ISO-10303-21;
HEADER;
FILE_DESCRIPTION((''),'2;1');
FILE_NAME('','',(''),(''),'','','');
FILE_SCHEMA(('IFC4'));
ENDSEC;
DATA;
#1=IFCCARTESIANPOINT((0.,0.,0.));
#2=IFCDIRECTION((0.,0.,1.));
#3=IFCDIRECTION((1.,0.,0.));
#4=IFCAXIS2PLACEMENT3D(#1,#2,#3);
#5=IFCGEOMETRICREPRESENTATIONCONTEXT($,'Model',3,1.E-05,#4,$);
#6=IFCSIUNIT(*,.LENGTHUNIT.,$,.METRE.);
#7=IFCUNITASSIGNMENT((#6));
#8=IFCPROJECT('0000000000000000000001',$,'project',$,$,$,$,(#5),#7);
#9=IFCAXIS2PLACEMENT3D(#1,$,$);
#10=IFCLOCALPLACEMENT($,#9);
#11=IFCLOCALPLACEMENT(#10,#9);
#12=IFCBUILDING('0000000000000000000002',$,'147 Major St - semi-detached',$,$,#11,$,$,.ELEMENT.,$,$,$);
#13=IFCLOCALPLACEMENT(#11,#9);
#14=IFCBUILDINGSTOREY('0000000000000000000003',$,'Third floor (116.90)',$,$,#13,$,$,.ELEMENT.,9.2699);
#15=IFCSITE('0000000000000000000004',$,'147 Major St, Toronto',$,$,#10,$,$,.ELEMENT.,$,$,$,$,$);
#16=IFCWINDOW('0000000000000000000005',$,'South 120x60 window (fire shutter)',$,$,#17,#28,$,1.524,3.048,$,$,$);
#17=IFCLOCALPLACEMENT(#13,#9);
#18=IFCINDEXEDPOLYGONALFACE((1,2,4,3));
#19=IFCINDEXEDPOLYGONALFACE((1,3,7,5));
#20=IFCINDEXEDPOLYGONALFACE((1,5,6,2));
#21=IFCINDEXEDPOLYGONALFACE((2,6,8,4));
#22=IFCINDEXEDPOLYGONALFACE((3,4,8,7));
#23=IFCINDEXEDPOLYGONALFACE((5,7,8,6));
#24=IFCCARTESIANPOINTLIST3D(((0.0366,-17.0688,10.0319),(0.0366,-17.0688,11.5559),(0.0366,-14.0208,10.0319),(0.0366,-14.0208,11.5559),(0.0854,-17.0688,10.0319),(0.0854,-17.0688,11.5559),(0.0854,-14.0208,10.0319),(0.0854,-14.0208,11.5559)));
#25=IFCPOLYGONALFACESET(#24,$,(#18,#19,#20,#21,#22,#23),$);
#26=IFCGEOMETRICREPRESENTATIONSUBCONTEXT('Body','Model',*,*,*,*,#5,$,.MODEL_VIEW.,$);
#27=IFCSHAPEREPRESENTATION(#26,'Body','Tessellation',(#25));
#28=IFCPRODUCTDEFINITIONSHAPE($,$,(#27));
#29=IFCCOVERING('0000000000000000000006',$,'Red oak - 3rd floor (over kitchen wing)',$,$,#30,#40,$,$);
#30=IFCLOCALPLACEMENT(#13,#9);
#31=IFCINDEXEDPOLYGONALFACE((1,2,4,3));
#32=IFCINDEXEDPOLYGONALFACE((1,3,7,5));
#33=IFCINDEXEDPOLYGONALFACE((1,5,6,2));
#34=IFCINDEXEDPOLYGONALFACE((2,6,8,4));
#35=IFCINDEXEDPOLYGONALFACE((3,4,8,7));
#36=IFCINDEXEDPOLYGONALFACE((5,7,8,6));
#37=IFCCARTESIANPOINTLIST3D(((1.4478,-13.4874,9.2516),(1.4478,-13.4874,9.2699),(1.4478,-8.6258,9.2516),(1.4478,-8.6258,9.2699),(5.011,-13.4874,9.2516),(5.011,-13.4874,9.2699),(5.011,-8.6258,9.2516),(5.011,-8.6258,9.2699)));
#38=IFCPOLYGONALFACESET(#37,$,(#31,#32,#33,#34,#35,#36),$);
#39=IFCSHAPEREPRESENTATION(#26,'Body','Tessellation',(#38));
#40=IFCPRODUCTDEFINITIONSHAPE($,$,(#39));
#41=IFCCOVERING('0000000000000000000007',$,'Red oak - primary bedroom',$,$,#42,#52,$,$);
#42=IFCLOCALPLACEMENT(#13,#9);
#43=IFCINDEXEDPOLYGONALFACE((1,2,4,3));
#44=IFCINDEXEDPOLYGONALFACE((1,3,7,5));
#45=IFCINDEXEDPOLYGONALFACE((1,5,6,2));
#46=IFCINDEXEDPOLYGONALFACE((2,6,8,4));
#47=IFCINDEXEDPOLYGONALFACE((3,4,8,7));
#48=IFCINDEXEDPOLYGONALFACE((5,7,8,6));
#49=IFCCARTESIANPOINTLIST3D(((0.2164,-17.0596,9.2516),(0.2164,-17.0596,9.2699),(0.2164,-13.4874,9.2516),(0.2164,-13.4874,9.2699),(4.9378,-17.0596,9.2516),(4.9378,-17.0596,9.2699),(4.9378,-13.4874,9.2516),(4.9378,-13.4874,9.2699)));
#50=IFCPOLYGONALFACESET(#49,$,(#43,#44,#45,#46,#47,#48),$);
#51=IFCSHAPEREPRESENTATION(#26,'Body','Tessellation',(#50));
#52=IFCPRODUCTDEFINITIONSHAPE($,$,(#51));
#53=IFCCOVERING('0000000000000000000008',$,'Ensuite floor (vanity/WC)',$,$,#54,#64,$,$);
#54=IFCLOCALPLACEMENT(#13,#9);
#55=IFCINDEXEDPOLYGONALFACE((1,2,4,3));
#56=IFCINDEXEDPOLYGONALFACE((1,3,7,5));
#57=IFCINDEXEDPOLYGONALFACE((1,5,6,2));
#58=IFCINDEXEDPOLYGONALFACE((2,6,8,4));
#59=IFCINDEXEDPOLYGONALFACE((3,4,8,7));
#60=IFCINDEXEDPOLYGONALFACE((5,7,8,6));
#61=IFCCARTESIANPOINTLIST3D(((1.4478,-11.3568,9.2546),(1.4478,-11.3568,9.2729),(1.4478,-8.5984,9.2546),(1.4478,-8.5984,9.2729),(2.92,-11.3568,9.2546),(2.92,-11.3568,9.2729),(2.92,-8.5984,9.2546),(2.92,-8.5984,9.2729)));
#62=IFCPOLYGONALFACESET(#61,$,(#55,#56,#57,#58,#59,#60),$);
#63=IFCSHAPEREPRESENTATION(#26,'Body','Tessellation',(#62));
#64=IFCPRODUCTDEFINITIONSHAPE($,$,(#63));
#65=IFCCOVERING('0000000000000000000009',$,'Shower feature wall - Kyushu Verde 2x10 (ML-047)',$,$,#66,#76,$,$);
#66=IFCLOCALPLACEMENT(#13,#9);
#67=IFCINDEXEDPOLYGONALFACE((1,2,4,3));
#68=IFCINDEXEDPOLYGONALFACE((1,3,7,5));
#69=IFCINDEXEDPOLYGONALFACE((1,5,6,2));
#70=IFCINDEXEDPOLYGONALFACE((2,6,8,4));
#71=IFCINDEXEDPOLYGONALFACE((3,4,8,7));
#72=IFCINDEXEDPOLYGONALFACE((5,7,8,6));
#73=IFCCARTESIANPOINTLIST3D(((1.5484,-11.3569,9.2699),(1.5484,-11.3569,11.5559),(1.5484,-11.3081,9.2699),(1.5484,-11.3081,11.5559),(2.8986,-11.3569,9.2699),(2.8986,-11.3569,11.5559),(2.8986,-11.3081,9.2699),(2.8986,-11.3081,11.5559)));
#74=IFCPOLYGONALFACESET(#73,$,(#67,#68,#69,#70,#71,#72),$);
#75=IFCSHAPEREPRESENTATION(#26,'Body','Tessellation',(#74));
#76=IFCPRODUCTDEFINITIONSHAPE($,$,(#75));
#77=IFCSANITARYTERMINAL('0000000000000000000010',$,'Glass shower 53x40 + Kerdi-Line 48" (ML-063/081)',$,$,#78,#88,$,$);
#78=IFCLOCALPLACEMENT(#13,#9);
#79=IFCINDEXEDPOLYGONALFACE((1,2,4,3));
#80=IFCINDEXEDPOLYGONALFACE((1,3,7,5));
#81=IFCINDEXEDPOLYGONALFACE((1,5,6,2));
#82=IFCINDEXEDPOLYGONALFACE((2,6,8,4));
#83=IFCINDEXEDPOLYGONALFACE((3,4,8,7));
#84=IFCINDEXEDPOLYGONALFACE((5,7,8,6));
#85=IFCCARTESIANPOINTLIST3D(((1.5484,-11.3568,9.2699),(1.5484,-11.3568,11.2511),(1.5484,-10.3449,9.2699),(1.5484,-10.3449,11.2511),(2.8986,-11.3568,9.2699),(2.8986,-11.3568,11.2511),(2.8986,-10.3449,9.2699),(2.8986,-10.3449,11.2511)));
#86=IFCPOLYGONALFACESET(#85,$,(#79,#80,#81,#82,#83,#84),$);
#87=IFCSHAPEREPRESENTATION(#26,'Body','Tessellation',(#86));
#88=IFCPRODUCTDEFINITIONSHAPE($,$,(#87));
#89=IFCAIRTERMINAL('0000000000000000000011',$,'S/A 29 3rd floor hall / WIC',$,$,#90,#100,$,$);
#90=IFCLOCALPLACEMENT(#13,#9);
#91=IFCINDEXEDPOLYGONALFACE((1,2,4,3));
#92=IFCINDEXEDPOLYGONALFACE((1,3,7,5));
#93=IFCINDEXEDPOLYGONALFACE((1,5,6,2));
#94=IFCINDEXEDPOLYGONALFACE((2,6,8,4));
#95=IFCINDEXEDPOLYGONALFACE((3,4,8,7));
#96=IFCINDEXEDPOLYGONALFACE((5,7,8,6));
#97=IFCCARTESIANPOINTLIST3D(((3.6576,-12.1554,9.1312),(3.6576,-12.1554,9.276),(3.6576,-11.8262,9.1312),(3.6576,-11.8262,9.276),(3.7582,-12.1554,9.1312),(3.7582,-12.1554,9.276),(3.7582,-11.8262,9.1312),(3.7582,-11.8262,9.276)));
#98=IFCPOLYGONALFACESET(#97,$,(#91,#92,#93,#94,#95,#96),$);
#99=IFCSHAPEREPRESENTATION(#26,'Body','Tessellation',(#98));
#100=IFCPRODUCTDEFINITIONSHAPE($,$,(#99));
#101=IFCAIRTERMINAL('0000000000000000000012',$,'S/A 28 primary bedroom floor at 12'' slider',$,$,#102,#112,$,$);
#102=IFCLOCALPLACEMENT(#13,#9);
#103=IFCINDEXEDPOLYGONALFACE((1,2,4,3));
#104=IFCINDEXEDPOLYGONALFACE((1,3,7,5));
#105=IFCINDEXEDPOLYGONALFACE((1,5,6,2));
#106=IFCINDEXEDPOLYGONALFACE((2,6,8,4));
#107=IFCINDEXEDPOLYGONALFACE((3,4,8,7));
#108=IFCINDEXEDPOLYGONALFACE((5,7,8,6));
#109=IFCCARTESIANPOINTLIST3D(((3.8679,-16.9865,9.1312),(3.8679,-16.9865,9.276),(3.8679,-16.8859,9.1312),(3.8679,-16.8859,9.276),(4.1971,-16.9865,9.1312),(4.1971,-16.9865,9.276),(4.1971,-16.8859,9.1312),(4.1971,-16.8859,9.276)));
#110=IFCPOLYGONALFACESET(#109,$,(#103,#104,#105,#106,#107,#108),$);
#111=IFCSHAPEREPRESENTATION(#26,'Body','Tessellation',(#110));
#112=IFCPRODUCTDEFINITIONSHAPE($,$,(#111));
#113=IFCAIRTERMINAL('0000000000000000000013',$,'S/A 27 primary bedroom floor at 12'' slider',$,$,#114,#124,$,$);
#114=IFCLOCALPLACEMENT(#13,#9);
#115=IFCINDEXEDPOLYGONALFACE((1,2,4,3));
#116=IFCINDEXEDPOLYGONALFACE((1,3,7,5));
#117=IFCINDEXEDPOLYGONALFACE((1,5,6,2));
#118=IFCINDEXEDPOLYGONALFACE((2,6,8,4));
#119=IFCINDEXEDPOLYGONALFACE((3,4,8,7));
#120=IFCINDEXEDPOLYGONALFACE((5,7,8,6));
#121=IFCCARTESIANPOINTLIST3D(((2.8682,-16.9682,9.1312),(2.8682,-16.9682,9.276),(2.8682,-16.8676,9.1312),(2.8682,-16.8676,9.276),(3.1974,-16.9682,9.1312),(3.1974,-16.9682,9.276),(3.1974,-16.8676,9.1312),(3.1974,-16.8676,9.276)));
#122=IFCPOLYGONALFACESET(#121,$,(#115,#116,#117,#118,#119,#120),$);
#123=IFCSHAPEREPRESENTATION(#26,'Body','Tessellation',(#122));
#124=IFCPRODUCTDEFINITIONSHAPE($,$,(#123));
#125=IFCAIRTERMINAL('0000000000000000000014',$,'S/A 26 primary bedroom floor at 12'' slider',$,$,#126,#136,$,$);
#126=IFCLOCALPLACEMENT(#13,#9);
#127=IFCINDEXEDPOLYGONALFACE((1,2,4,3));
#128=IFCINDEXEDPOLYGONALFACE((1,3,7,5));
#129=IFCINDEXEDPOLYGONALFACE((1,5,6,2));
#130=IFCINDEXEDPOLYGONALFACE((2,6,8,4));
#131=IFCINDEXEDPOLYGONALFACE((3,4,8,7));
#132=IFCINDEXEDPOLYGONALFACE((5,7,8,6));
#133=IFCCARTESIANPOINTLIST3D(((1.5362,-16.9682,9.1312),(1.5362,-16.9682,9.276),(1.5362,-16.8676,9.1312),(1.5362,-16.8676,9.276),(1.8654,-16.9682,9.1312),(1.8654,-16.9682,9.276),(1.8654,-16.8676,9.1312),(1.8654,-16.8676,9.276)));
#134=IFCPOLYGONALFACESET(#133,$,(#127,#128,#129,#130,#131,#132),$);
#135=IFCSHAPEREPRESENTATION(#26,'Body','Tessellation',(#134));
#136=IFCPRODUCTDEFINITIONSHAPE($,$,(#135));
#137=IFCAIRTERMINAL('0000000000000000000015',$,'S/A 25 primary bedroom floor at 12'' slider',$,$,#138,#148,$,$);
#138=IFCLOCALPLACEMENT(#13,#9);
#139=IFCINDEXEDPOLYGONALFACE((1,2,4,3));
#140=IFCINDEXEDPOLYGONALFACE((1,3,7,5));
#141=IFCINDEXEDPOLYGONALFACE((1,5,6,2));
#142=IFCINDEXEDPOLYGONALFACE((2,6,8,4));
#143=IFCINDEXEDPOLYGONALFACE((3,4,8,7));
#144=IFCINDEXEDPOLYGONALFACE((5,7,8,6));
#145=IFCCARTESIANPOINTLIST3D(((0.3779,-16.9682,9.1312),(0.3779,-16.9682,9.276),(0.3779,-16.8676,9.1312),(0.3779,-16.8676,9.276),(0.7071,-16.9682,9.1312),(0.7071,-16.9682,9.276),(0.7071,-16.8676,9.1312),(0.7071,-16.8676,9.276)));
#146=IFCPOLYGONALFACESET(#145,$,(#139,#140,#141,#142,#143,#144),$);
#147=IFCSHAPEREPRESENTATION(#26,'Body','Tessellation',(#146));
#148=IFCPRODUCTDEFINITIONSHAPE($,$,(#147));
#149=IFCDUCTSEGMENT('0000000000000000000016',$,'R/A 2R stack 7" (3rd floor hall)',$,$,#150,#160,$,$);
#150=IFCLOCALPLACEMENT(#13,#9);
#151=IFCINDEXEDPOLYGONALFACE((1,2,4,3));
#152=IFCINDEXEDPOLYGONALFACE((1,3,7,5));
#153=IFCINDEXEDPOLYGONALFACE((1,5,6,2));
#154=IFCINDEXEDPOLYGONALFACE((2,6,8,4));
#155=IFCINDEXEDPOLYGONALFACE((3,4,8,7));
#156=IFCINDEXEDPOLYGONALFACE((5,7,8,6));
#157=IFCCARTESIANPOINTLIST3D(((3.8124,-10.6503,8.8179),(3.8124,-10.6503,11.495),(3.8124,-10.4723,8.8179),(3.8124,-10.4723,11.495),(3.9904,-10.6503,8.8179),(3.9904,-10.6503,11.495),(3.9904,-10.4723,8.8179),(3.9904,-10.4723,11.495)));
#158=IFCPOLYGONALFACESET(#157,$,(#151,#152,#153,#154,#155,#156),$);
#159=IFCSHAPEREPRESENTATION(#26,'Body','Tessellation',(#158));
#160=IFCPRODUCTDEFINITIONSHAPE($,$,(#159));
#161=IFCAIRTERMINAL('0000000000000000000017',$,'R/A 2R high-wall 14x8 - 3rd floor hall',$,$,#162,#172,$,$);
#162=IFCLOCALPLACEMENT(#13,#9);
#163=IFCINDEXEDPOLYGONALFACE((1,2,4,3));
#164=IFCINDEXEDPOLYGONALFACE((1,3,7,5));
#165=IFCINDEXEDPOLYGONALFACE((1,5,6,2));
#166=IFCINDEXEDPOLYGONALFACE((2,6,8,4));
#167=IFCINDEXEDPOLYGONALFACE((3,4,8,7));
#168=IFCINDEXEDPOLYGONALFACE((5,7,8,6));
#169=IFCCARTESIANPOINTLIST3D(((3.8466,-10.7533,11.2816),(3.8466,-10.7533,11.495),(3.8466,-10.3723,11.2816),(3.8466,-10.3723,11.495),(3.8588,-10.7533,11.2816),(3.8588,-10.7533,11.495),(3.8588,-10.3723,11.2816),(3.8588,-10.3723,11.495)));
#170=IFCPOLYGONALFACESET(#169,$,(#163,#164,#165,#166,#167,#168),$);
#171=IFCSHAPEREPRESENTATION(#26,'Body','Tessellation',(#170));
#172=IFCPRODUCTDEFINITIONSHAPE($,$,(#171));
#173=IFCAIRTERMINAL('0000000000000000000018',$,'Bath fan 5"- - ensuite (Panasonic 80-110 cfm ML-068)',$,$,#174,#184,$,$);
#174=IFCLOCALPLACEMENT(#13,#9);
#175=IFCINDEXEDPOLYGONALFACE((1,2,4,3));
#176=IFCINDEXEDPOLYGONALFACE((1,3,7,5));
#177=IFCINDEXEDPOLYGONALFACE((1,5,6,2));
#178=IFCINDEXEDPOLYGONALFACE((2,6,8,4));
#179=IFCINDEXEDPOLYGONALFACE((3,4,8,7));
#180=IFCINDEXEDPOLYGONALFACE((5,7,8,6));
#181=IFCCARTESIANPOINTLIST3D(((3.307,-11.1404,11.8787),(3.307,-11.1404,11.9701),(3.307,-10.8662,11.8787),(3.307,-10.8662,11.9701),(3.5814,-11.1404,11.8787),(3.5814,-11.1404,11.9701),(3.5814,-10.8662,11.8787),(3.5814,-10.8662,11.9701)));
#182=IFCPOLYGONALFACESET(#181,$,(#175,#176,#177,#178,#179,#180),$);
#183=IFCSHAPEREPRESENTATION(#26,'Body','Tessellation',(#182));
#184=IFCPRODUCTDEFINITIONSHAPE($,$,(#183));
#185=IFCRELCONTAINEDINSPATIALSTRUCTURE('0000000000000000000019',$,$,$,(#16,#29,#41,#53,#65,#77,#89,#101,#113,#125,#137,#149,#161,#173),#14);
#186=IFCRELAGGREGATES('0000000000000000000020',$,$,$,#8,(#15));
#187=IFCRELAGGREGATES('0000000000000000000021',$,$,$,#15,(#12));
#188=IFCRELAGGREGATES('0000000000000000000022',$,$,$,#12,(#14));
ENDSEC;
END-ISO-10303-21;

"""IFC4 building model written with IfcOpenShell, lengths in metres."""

from ifc_helpers import new_model, si_unit, frame, origin, origin_with_axes, place, context, subcontext, project, spatial, rectangle, extrude, element, save


model = new_model("IFC4")

# Units and contexts
model_context = context("Model", 3, precision=1e-05, world=origin_with_axes())
body_context = subcontext(model_context, "Body", "Model", "MODEL_VIEW")
ifc_project = project(units=[si_unit("LENGTHUNIT", "METRE")], contexts=[model_context])

# Site, building, storey
site_placement = place(None, origin())
site = spatial("IfcSite", under=ifc_project, at=site_placement, Name="147 Major St, Toronto", CompositionType="ELEMENT")
building_placement = place(site_placement, origin())
building = spatial("IfcBuilding", under=site, at=building_placement, Name="147 Major St - semi-detached", CompositionType="ELEMENT")
storey_placement = place(building_placement, origin())
storey = spatial("IfcBuildingStorey", under=building, at=storey_placement, Name="Third floor (116.90)", CompositionType="ELEMENT", Elevation=9.2699)

# Window
window_placement = place(storey_placement, frame((0.061, -15.5448, 10.0319)))
element("IfcWindow", 1, at=window_placement, inside=storey, Name="South 120x60 window (fire shutter)", OverallHeight=1.524, OverallWidth=3.048, context=body_context, shape_type="SweptSolid", body=[
    extrude(rectangle(XDim=0.0488, YDim=3.048), origin_with_axes(), (0.0, 0.0, 1.0), 1.524),
])

# Coverings
covering_1_placement = place(storey_placement, frame((3.2294, -11.0566, 9.2516)))
element("IfcCovering", 2, at=covering_1_placement, inside=storey, Name="Red oak - 3rd floor (over kitchen wing)", context=body_context, shape_type="SweptSolid", body=[
    extrude(rectangle(XDim=3.5631, YDim=4.8616), origin_with_axes(), (0.0, 0.0, 1.0), 0.0183),
])
covering_2_placement = place(storey_placement, frame((2.5771, -15.2735, 9.2516)))
element("IfcCovering", 3, at=covering_2_placement, inside=storey, Name="Red oak - primary bedroom", context=body_context, shape_type="SweptSolid", body=[
    extrude(rectangle(XDim=4.7214, YDim=3.5723), origin_with_axes(), (0.0, 0.0, 1.0), 0.0183),
])
covering_3_placement = place(storey_placement, frame((2.1839, -9.9776, 9.2546)))
element("IfcCovering", 4, at=covering_3_placement, inside=storey, Name="Ensuite floor (vanity/WC)", context=body_context, shape_type="SweptSolid", body=[
    extrude(rectangle(XDim=1.4722, YDim=2.7584), origin_with_axes(), (0.0, 0.0, 1.0), 0.0183),
])
covering_4_placement = place(storey_placement, frame((2.2235, -11.3325, 9.2699)))
element("IfcCovering", 5, at=covering_4_placement, inside=storey, Name="Shower feature wall - Kyushu Verde 2x10 (ML-047)", context=body_context, shape_type="SweptSolid", body=[
    extrude(rectangle(XDim=1.3503, YDim=0.0488), origin_with_axes(), (0.0, 0.0, 1.0), 2.286),
])

# Sanitary terminal
sanitary_terminal_placement = place(storey_placement, frame((2.2235, -10.8509, 9.2699)))
element("IfcSanitaryTerminal", 6, at=sanitary_terminal_placement, inside=storey, Name="Glass shower 53x40 + Kerdi-Line 48\" (ML-063/081)", context=body_context, shape_type="SweptSolid", body=[
    extrude(rectangle(XDim=1.3503, YDim=1.0119), origin_with_axes(), (0.0, 0.0, 1.0), 1.9812),
])

# Air terminals
air_terminal_1_placement = place(storey_placement, frame((3.7079, -11.9908, 9.1312)))
element("IfcAirTerminal", 7, at=air_terminal_1_placement, inside=storey, Name="S/A 29 3rd floor hall / WIC", context=body_context, shape_type="SweptSolid", body=[
    extrude(rectangle(XDim=0.1006, YDim=0.3292), origin_with_axes(), (0.0, 0.0, 1.0), 0.1448),
])
for number, where, name in (
    (8, (4.0325, -16.9362, 9.1312), "S/A 28 primary bedroom floor at 12' slider"),
    (9, (3.0328, -16.9179, 9.1312), "S/A 27 primary bedroom floor at 12' slider"),
    (10, (1.7008, -16.9179, 9.1312), "S/A 26 primary bedroom floor at 12' slider"),
    (11, (0.5425, -16.9179, 9.1312), "S/A 25 primary bedroom floor at 12' slider"),
):
    element("IfcAirTerminal", number, at=place(storey_placement, frame(where)), inside=storey, Name=name, context=body_context, shape_type="SweptSolid", body=[
        extrude(rectangle(XDim=0.3292, YDim=0.1006), origin_with_axes(), (0.0, 0.0, 1.0), 0.1448),
    ])

# Duct segment
duct_segment_placement = place(storey_placement, frame((3.9014, -10.5613, 8.8179)))
element("IfcDuctSegment", 12, at=duct_segment_placement, inside=storey, Name="R/A 2R stack 7\" (3rd floor hall)", context=body_context, shape_type="SweptSolid", body=[
    extrude(rectangle(XDim=0.178, YDim=0.178), origin_with_axes(), (0.0, 0.0, 1.0), 2.6771),
])

# Air terminals
air_terminal_2_placement = place(storey_placement, frame((3.8527, -10.5628, 11.2816)))
element("IfcAirTerminal", 13, at=air_terminal_2_placement, inside=storey, Name="R/A 2R high-wall 14x8 - 3rd floor hall", context=body_context, shape_type="SweptSolid", body=[
    extrude(rectangle(XDim=0.0122, YDim=0.381), origin_with_axes(), (0.0, 0.0, 1.0), 0.2134),
])
air_terminal_3_placement = place(storey_placement, frame((3.4442, -11.0033, 11.8787)))
element("IfcAirTerminal", 14, at=air_terminal_3_placement, inside=storey, Name="Bath fan 5\"- - ensuite (Panasonic 80-110 cfm ML-068)", context=body_context, shape_type="SweptSolid", body=[
    extrude(rectangle(XDim=0.2743, YDim=0.2743), origin_with_axes(), (0.0, 0.0, 1.0), 0.0914),
])

save(model, "model.ifc")
